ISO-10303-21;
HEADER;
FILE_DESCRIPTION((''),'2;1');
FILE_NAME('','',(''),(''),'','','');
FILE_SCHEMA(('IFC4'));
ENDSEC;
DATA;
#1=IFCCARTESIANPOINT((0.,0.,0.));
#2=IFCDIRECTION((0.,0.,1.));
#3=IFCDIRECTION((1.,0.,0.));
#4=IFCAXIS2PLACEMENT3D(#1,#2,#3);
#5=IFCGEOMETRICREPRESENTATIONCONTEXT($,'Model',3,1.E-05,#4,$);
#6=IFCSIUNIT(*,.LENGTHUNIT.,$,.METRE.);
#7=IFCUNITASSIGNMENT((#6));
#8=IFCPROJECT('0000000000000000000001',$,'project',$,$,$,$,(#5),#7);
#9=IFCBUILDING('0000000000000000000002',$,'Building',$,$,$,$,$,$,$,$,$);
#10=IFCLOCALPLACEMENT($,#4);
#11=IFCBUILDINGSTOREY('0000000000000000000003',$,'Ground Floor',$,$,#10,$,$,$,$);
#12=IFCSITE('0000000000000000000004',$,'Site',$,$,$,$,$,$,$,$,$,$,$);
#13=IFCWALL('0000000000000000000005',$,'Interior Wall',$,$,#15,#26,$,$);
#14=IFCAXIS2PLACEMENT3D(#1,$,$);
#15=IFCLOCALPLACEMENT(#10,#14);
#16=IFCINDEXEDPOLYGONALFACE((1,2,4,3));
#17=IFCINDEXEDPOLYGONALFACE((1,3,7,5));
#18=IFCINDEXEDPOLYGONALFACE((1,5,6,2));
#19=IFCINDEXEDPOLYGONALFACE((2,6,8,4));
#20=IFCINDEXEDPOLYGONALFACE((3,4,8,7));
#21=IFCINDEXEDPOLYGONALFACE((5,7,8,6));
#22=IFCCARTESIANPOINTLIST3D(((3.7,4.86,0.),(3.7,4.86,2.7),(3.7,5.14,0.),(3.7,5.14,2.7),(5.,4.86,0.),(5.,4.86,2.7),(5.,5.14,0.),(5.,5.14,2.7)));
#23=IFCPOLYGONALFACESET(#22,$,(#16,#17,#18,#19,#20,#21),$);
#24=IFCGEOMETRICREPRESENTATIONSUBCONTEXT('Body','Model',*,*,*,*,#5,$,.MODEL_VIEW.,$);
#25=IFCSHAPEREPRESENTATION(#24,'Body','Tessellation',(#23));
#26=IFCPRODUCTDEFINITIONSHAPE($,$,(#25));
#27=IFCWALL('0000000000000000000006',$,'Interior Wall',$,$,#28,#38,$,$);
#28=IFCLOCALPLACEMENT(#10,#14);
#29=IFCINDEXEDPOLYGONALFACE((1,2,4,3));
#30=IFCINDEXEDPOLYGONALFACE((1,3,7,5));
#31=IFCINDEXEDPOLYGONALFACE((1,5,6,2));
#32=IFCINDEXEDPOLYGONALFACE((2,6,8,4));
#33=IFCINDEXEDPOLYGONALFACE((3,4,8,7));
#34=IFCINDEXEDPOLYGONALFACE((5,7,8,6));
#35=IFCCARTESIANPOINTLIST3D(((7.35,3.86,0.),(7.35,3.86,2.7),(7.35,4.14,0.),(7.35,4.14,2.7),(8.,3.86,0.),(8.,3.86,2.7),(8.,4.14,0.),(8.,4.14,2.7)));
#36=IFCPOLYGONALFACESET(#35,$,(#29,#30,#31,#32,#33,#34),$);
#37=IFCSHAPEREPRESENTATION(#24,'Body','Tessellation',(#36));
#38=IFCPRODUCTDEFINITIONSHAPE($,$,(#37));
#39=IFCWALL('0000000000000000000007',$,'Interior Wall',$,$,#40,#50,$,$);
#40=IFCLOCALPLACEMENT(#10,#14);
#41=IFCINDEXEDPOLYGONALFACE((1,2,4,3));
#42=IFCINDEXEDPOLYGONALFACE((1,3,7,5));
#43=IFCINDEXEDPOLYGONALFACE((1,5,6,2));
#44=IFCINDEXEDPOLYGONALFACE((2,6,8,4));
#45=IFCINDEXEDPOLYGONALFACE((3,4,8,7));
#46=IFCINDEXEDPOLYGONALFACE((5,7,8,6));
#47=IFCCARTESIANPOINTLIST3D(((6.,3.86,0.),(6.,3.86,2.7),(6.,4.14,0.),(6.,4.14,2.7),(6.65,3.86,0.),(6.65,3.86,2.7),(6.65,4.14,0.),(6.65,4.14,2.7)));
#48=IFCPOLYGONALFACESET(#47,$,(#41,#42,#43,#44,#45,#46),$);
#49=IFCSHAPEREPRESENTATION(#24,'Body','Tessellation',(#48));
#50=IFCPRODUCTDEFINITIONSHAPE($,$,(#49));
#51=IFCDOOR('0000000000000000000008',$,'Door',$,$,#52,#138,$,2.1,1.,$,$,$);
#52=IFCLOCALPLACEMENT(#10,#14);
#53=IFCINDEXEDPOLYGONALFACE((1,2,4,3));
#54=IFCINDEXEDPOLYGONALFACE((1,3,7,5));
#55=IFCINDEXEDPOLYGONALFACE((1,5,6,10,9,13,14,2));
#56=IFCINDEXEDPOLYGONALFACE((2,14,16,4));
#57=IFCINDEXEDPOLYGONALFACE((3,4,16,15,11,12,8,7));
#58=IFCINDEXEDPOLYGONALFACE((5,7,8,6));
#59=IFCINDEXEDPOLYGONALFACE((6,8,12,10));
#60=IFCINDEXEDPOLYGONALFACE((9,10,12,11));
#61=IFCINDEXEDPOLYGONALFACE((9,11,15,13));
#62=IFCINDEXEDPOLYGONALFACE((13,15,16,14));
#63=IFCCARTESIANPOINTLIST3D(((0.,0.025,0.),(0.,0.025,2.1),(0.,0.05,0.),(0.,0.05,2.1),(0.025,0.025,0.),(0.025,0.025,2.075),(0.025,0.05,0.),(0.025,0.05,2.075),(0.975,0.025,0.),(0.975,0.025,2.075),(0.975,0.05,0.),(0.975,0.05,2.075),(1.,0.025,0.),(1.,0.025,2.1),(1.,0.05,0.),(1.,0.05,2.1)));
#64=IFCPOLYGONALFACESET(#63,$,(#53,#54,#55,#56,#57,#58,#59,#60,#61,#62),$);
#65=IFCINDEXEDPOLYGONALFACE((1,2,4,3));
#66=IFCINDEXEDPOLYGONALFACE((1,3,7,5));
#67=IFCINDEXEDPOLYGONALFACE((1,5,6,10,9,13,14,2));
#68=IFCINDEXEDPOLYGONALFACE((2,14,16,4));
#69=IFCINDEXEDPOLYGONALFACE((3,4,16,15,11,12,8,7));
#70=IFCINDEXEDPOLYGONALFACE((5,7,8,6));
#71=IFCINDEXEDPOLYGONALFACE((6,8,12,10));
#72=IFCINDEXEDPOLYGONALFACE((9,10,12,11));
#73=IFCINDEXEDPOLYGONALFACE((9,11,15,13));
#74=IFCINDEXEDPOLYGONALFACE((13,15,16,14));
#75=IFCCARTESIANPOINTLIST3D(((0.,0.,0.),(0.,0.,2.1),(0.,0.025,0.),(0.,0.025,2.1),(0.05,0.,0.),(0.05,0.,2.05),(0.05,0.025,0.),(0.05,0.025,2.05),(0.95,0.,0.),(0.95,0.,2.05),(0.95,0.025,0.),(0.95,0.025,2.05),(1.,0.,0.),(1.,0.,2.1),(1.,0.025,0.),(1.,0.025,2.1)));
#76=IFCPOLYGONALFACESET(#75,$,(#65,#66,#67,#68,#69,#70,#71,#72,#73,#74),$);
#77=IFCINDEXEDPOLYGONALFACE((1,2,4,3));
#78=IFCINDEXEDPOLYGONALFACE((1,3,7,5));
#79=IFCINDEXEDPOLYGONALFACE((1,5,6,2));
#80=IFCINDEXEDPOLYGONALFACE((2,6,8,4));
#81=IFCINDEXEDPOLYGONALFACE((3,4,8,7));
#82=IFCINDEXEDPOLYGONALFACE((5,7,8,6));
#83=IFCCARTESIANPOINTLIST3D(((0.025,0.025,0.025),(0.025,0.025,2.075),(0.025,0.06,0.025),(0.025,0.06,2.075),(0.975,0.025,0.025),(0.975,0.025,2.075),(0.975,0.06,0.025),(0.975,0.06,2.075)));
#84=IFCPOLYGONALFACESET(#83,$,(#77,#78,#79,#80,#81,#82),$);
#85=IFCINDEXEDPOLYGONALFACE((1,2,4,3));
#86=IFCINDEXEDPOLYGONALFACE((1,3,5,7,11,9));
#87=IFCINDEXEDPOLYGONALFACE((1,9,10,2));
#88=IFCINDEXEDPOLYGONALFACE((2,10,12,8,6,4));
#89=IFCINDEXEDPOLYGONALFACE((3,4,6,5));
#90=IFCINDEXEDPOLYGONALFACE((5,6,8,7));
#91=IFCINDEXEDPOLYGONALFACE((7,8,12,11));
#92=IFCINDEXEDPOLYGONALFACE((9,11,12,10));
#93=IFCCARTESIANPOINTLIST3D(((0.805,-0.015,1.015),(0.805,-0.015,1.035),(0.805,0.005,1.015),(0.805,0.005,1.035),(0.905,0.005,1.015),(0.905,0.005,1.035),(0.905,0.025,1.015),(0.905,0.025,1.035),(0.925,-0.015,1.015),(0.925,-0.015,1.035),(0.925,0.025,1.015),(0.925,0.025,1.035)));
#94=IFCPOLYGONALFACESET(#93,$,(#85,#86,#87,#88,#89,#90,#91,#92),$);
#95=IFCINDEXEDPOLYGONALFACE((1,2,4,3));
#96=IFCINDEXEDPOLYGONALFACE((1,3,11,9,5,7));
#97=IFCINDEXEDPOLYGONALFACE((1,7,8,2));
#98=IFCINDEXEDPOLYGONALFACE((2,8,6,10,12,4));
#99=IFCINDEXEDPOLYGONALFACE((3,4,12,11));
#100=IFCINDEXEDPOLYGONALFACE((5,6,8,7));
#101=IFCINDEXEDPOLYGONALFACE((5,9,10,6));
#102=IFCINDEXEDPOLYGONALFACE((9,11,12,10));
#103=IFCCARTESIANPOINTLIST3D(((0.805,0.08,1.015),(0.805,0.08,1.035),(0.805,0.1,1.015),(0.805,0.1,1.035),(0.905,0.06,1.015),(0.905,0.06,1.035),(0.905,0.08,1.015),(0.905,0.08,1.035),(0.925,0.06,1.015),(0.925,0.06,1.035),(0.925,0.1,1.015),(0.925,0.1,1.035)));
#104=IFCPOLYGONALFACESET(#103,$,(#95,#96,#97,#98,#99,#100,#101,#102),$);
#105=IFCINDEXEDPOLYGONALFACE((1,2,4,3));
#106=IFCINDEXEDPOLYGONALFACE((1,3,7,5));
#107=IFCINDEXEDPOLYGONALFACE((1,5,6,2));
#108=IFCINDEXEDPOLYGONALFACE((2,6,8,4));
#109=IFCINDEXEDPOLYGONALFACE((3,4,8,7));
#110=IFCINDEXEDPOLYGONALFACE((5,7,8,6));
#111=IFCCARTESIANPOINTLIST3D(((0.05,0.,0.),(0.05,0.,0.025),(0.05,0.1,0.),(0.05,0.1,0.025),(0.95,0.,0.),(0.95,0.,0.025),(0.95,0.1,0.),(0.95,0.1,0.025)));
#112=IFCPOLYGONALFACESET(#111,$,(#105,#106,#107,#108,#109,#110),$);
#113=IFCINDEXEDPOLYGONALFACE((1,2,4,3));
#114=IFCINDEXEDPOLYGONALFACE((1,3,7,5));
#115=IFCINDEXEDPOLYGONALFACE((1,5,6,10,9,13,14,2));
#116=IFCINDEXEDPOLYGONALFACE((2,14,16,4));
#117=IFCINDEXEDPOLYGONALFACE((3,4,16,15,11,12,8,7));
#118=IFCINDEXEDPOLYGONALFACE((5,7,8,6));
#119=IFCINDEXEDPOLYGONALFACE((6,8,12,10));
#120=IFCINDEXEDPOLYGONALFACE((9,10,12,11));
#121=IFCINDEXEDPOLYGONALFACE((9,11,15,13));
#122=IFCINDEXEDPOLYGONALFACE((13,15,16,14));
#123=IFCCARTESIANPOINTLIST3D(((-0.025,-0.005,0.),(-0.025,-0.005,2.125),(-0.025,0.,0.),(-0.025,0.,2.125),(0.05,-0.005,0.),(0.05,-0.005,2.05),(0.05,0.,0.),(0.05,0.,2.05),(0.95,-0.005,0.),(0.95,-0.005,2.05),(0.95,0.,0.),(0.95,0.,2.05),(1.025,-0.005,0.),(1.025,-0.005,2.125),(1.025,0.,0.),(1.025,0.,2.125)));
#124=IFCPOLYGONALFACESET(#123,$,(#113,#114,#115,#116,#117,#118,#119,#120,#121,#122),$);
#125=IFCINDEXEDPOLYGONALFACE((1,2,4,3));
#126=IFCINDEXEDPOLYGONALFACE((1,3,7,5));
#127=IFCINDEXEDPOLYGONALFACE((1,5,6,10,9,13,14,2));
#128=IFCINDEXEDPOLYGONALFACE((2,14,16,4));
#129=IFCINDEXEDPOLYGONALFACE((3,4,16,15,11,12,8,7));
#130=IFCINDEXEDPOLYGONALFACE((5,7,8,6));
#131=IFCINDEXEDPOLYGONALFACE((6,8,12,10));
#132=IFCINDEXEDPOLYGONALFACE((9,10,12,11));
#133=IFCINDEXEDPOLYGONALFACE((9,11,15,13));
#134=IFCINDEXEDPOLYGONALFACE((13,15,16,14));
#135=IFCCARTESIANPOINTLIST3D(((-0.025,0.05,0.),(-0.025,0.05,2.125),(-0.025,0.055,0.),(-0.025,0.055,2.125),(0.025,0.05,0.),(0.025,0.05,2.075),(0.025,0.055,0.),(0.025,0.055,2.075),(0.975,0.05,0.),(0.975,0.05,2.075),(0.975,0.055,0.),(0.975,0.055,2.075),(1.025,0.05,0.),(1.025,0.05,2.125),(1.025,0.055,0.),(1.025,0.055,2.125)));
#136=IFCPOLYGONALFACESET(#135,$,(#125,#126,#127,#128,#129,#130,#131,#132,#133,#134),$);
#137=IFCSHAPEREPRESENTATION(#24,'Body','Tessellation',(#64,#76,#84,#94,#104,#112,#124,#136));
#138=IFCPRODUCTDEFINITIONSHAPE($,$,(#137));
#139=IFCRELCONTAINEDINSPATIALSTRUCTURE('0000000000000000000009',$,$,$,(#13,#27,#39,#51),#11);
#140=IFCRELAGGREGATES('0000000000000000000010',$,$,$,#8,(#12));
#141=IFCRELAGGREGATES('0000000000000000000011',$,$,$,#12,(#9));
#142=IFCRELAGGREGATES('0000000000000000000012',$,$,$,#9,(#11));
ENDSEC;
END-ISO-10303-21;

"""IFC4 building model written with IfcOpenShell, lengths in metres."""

from ifc_helpers import new_model, si_unit, frame, origin_with_axes, place, context, subcontext, project, spatial, line, indexed_curve, outline, extrude, element, save


model = new_model("IFC4")

# Units and contexts
model_context = context("Model", 3, precision=1e-05, world=origin_with_axes())
body_context = subcontext(model_context, "Body", "Model", "MODEL_VIEW")
ifc_project = project(units=[si_unit("LENGTHUNIT", "METRE")], contexts=[model_context])

# Site, building, storey
site = spatial("IfcSite", under=ifc_project, Name="Site")
building = spatial("IfcBuilding", under=site, Name="Building")
storey_placement = place(None, origin_with_axes())
storey = spatial("IfcBuildingStorey", under=building, at=storey_placement, Name="Ground Floor")

# Walls
wall_1_placement = place(storey_placement, frame((5.0, 5.0, 0.0), z_axis=(0.0, 0.0, 1.0), x_axis=(-1.0, 0.0, 0.0)))
element("IfcWall", 1, at=wall_1_placement, inside=storey, Name="Interior Wall", context=body_context, shape_type="SweptSolid", body=[
    extrude(outline(indexed_curve([(0.0, 0.0), (0.0, 0.28), (1.3, 0.28), (1.3, 0.0), (0.0, 0.0)], self_intersect=False)), frame((0.0, -0.14, 0.0), z_axis=(0.0, 0.0, 1.0), x_axis=(1.0, 0.0, 0.0)), (0.0, 0.0, 1.0), 2.7),
])
for number, where, z_axis, x_axis, name in (
    (2, (8.0, 4.0, 0.0), (0.0, 0.0, 1.0), (-1.0, 0.0, 0.0), "Interior Wall"),
    (3, (6.65, 4.0, 0.0), (0.0, 0.0, 1.0), (-1.0, 0.0, 0.0), "Interior Wall"),
):
    element("IfcWall", number, at=place(storey_placement, frame(where, z_axis=z_axis, x_axis=x_axis)), inside=storey, Name=name, context=body_context, shape_type="SweptSolid", body=[
        extrude(outline(indexed_curve([(0.0, 0.0), (0.0, 0.28), (0.65, 0.28), (0.65, 0.0), (0.0, 0.0)], self_intersect=False)), frame((0.0, -0.14, 0.0), z_axis=(0.0, 0.0, 1.0), x_axis=(1.0, 0.0, 0.0)), (0.0, 0.0, 1.0), 2.7),
    ])

# Door
door_1_placement = place(storey_placement, origin_with_axes())
element("IfcDoor", 4, at=door_1_placement, inside=storey, Name="Door", OverallHeight=2.1, OverallWidth=1.0, context=body_context, shape_type="SweptSolid", body=[
    extrude(outline(indexed_curve([(0.0, 0.0), (0.0, 2.1), (1.0, 2.1), (1.0, 0.0), (0.975, 0.0), (0.975, 2.075), (0.025, 2.075), (0.025, 0.0)], segments=[line(1, 2, 3, 4, 5, 6, 7, 8, 1)])), frame((0.0, 0.025, 0.0), z_axis=(0.0, -1.0, 0.0), x_axis=(1.0, 0.0, 0.0)), (0.0, 0.0, -1.0), 0.025),
    extrude(outline(indexed_curve([(0.0, 0.0), (0.0, 2.1), (1.0, 2.1), (1.0, 0.0), (0.95, 0.0), (0.95, 2.05), (0.05, 2.05), (0.05, 0.0)], segments=[line(1, 2, 3, 4, 5, 6, 7, 8, 1)])), frame((0.0, 0.0, 0.0), z_axis=(0.0, -1.0, 0.0), x_axis=(1.0, 0.0, 0.0)), (0.0, 0.0, -1.0), 0.025),
    extrude(outline(indexed_curve([(0.0, 0.0), (0.95, 0.0), (0.95, 0.035), (0.0, 0.035)], segments=[line(1, 2, 3, 4, 1)])), frame((0.025, 0.025, 0.025), z_axis=(0.0, 0.0, 1.0), x_axis=(1.0, 0.0, 0.0)), (0.0, 0.0, 1.0), 2.05),
    extrude(outline(indexed_curve([(0.0, 0.0), (0.0, -0.04), (-0.12, -0.04), (-0.12, -0.02), (-0.02, -0.02), (-0.02, 0.0)], segments=[line(1, 2, 3, 4, 5, 6, 1)])), frame((0.925, 0.025, 1.015), z_axis=(0.0, 0.0, 1.0), x_axis=(1.0, 0.0, 0.0)), (0.0, 0.0, 1.0), 0.02),
    extrude(outline(indexed_curve([(0.0, 0.0), (0.0, 0.04), (-0.12, 0.04), (-0.12, 0.02), (-0.02, 0.02), (-0.02, 0.0)], segments=[line(1, 2, 3, 4, 5, 6, 1)])), frame((0.925, 0.06, 1.015), z_axis=(0.0, 0.0, 1.0), x_axis=(1.0, 0.0, 0.0)), (0.0, 0.0, 1.0), 0.02),
    extrude(outline(indexed_curve([(0.0, 0.0), (0.9, 0.0), (0.9, 0.1), (0.0, 0.1)], segments=[line(1, 2, 3, 4, 1)])), frame((0.05, 0.0, 0.0), z_axis=(0.0, 0.0, 1.0), x_axis=(1.0, 0.0, 0.0)), (0.0, 0.0, 1.0), 0.025),
    extrude(outline(indexed_curve([(0.0, 0.0), (0.0, 2.125), (1.05, 2.125), (1.05, 0.0), (0.975, 0.0), (0.975, 2.05), (0.075, 2.05), (0.075, 0.0)], segments=[line(1, 2, 3, 4, 5, 6, 7, 8, 1)])), frame((-0.025, -0.005, 0.0), z_axis=(0.0, -1.0, 0.0), x_axis=(1.0, 0.0, 0.0)), (0.0, 0.0, -1.0), 0.005),
    extrude(outline(indexed_curve([(0.0, 0.0), (0.0, 2.125), (1.05, 2.125), (1.05, 0.0), (1.0, 0.0), (1.0, 2.075), (0.05, 2.075), (0.05, 0.0)], segments=[line(1, 2, 3, 4, 5, 6, 7, 8, 1)])), frame((-0.025, 0.05, 0.0), z_axis=(0.0, -1.0, 0.0), x_axis=(1.0, 0.0, 0.0)), (0.0, 0.0, -1.0), 0.005),
])

save(model, "model.ifc")
